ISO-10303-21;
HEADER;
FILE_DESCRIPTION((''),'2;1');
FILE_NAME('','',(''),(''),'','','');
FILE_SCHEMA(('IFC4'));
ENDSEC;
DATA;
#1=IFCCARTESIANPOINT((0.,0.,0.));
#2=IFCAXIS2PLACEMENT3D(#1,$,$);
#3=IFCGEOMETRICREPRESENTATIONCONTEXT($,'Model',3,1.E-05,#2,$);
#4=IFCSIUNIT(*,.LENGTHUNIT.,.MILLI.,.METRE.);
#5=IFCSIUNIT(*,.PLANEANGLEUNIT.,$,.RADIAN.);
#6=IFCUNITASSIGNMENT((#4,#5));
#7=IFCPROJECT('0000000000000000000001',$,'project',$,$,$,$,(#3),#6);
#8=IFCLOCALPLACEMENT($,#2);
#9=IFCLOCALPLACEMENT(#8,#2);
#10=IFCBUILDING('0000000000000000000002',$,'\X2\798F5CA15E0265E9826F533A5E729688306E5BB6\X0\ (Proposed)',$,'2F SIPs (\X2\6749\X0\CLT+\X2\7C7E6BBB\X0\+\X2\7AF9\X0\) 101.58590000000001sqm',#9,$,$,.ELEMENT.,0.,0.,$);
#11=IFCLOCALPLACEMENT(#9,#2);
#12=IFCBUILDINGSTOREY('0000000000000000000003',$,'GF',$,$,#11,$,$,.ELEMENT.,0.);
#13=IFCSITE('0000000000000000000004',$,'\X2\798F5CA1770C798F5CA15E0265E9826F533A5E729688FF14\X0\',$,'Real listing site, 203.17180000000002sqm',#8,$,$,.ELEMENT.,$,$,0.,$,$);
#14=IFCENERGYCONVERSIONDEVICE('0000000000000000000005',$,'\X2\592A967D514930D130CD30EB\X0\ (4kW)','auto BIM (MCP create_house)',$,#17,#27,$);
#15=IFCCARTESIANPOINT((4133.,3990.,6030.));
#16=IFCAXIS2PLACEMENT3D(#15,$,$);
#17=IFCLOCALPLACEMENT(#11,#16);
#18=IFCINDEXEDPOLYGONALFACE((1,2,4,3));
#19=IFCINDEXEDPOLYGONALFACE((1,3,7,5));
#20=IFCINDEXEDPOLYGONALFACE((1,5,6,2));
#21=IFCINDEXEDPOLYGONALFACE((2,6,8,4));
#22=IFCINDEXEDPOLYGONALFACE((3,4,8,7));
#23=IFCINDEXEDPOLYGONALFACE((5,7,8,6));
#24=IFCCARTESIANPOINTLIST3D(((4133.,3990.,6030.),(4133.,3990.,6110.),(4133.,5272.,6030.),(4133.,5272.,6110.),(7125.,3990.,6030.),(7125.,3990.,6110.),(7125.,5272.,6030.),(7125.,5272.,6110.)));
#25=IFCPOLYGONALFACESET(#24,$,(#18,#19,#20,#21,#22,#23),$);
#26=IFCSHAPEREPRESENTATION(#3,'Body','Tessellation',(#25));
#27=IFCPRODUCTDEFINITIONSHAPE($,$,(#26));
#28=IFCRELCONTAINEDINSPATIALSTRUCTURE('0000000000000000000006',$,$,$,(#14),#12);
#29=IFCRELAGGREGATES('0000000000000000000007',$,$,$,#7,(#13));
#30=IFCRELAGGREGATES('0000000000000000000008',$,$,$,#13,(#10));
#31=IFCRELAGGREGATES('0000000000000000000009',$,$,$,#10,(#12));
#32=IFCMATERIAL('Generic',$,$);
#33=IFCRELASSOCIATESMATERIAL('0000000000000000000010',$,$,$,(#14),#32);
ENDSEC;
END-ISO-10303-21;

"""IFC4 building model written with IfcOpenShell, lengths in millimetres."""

from ifc_helpers import new_model, si_unit, frame, frame_2d, origin, place, context, project, spatial, rectangle, extrude, material, element, save


model = new_model("IFC4")

# Units and contexts
model_context = context("Model", 3, precision=1e-05, world=origin())
ifc_project = project(units=[si_unit("LENGTHUNIT", "METRE", prefix="MILLI"), si_unit("PLANEANGLEUNIT", "RADIAN")], contexts=[model_context])

# Site, building, storey
site_placement = place(None, origin())
site = spatial("IfcSite", under=ifc_project, at=site_placement, Name="福岡県福岡市早良区干隈４", ObjectType="Real listing site, 203.17180000000002sqm", CompositionType="ELEMENT", RefElevation=0.0)
building_placement = place(site_placement, origin())
building = spatial("IfcBuilding", under=site, at=building_placement, Name="福岡市早良区干隈の家 (Proposed)", ObjectType="2F SIPs (杉CLT+籾殻+竹) 101.58590000000001sqm", CompositionType="ELEMENT", ElevationOfRefHeight=0.0, ElevationOfTerrain=0.0)
storey_placement = place(building_placement, origin())
storey = spatial("IfcBuildingStorey", under=building, at=storey_placement, Name="GF", CompositionType="ELEMENT", Elevation=0.0)

# Shared definitions
ifc_material_1 = material(Name="Generic")

# Energy conversion device
energy_conversion_device_placement = place(storey_placement, frame((4133.0, 3990.0, 6030.0)))
element("IfcEnergyConversionDevice", 1, at=energy_conversion_device_placement, inside=storey, material=ifc_material_1, Name="太陽光パネル (4kW)", Description="auto BIM (MCP create_house)", context=model_context, shape_type="SweptSolid", body=[
    extrude(rectangle(XDim=2992.0, YDim=1282.0, at=frame_2d((1496.0, 641.0))), frame((4133.0, 3990.0, 6030.0)), (0.0, 0.0, 1.0), 80.0),
])

save(model, "model.ifc")
